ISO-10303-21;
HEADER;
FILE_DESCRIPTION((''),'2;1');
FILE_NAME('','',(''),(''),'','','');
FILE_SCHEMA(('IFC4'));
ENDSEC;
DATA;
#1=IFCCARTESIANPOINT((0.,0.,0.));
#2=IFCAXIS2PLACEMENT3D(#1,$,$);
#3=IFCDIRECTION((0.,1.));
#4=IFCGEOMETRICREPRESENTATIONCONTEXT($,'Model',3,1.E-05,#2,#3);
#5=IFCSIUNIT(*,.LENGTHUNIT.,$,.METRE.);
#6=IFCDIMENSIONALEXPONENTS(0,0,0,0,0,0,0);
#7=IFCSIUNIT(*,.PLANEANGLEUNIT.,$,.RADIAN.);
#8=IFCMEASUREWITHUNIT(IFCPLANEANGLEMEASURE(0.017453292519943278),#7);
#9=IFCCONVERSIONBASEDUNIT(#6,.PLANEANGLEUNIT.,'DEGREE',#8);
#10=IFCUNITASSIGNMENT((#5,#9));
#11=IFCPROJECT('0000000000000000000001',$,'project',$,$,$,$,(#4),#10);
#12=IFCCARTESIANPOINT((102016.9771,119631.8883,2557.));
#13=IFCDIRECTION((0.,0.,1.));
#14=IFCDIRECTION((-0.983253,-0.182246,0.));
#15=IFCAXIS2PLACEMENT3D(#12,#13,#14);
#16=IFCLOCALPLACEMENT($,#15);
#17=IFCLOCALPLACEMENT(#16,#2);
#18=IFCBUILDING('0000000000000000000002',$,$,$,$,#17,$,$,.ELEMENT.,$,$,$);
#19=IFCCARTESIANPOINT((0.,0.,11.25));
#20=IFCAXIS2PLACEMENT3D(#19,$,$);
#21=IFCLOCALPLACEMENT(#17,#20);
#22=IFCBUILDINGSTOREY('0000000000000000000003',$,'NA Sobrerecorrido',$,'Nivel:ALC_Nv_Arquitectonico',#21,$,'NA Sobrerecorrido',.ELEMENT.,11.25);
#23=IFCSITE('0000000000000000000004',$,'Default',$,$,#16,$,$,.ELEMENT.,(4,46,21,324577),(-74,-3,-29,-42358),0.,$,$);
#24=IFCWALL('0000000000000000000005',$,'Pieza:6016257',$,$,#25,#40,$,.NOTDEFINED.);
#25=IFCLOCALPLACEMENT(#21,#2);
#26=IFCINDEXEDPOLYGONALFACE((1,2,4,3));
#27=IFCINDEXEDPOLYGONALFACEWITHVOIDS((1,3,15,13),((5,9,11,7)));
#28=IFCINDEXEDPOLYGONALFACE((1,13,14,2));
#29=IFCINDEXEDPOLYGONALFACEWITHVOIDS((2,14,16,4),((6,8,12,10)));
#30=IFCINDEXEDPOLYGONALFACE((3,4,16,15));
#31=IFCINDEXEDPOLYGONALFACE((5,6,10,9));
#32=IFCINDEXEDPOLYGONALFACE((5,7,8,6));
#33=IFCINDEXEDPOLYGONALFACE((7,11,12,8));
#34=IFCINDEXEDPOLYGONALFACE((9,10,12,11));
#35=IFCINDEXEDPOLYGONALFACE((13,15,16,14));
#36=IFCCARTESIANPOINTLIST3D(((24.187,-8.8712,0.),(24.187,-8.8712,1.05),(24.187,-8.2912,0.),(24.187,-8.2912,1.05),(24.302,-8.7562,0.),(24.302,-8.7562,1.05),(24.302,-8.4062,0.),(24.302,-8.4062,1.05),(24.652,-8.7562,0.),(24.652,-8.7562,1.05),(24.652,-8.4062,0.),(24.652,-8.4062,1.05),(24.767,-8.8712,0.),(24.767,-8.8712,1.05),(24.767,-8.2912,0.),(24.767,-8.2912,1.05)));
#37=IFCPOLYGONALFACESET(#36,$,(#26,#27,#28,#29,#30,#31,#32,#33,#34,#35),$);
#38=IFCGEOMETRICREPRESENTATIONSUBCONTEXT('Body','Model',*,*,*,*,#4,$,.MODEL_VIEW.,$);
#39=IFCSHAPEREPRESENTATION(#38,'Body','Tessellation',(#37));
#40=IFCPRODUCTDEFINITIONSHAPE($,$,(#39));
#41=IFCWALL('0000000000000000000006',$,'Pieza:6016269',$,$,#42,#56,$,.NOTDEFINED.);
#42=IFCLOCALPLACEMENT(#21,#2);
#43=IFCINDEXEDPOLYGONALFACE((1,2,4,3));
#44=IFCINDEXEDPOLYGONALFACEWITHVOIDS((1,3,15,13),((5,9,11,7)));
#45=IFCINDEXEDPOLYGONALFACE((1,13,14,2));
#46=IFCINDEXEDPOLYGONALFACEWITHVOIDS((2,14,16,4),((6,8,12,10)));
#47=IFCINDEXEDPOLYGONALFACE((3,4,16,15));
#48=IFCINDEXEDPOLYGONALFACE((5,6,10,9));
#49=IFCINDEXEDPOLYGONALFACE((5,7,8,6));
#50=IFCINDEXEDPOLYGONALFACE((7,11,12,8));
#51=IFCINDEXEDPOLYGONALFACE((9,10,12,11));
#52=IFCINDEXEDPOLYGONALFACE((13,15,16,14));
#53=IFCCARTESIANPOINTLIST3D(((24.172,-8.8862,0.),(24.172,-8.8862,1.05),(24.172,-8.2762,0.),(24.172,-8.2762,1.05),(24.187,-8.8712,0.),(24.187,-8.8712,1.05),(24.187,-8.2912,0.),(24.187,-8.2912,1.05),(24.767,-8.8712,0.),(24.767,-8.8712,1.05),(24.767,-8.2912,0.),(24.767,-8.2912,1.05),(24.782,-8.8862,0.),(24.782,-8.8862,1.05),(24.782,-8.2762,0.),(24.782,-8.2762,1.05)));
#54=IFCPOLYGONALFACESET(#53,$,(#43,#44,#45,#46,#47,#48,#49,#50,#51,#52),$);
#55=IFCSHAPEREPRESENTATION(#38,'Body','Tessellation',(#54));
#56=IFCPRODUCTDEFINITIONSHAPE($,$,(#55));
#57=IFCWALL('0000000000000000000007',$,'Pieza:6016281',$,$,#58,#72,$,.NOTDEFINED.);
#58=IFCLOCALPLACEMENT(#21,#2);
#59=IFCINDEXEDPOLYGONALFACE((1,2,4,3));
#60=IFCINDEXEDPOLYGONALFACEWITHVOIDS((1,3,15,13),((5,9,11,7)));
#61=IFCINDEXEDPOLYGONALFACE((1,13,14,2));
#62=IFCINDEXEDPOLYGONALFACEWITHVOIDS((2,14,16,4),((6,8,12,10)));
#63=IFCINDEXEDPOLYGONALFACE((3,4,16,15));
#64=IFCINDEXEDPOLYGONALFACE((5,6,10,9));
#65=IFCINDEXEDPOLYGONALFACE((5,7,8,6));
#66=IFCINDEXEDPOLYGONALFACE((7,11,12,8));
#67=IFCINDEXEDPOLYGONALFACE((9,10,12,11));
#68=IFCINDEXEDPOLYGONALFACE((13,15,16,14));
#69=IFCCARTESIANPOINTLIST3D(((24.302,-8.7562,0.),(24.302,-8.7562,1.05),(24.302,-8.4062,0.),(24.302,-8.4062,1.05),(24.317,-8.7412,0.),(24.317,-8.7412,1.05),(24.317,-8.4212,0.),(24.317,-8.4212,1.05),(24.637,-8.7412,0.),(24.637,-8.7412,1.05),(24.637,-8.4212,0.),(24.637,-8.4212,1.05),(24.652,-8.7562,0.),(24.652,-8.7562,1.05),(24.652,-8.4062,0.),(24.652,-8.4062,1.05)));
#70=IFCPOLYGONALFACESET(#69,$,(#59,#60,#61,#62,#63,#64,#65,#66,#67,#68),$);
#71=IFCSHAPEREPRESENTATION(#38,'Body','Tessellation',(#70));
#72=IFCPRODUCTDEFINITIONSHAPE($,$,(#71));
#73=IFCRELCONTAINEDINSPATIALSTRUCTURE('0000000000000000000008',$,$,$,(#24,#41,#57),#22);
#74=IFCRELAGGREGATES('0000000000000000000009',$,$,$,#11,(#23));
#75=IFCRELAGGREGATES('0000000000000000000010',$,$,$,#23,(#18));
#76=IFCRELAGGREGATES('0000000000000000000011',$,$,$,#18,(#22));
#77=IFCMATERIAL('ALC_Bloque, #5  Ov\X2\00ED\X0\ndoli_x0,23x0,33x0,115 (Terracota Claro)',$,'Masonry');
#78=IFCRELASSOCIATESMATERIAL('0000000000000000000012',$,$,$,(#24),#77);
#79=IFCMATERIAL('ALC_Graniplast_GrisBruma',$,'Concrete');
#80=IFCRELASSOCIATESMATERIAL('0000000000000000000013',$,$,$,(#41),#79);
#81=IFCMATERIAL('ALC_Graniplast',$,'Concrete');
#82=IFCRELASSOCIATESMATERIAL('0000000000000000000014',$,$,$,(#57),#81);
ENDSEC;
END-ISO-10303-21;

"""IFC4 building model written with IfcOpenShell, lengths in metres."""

from ifc_helpers import new_model, entity, si_unit, converted_unit, direction, frame, origin, place, context, subcontext, project, spatial, polyline, outline, extrude, material, element, save


model = new_model("IFC4")

# Units and contexts
model_context = context("Model", 3, precision=1e-05, world=origin(), true_north=direction((0.0, 1.0)))
body_context = subcontext(model_context, "Body", "Model", "MODEL_VIEW")
ifc_project = project(units=[si_unit("LENGTHUNIT", "METRE"), converted_unit("PLANEANGLEUNIT", "DEGREE", entity("IfcPlaneAngleMeasure", 0.017453292519943278), si_unit("PLANEANGLEUNIT", "RADIAN"), dimensions=[0, 0, 0, 0, 0, 0, 0])], contexts=[model_context])

# Site, building, storey
site_placement = place(None, frame((102016.9771, 119631.8883, 2557.0), z_axis=(0.0, 0.0, 1.0), x_axis=(-0.983253, -0.182246, 0.0)))
site = spatial("IfcSite", under=ifc_project, at=site_placement, Name="Default", CompositionType="ELEMENT", RefLatitude=(4, 46, 21, 324577), RefLongitude=(-74, -3, -29, -42358), RefElevation=0.0)
building_placement = place(site_placement, origin())
building = spatial("IfcBuilding", under=site, at=building_placement, CompositionType="ELEMENT")
storey_placement = place(building_placement, frame((0.0, 0.0, 11.25)))
storey = spatial("IfcBuildingStorey", under=building, at=storey_placement, Name="NA Sobrerecorrido", ObjectType="Nivel:ALC_Nv_Arquitectonico", LongName="NA Sobrerecorrido", CompositionType="ELEMENT", Elevation=11.25)

# Walls
ifc_material_1 = material(Name="ALC_Bloque, #5  Ovíndoli_x0,23x0,33x0,115 (Terracota Claro)", Category="Masonry")
wall_1_placement = place(storey_placement, frame((0.0, 0.0, -1.65)))
element("IfcWall", 1, at=wall_1_placement, inside=storey, material=ifc_material_1, Name="Pieza:6016257", PredefinedType="NOTDEFINED", context=body_context, shape_type="SweptSolid", body=[
    extrude(outline(polyline([(-0.29, -0.29), (0.29, -0.29), (0.29, 0.29), (-0.29, 0.29), (-0.29, -0.29)]), holes=[polyline([(-0.175, 0.175), (0.175, 0.175), (0.175, -0.175), (-0.175, -0.175), (-0.175, 0.175)])]), frame((24.477, -8.5812, 1.65), z_axis=(0.0, 0.0, 1.0), x_axis=(0.0, 1.0, 0.0)), (0.0, 0.0, 1.0), 1.05),
])
ifc_material_2 = material(Name="ALC_Graniplast_GrisBruma", Category="Concrete")
wall_2_placement = place(storey_placement, frame((0.0, 0.0, -1.65)))
element("IfcWall", 2, at=wall_2_placement, inside=storey, material=ifc_material_2, Name="Pieza:6016269", PredefinedType="NOTDEFINED", context=body_context, shape_type="SweptSolid", body=[
    extrude(outline(polyline([(-0.305, -0.305), (0.305, -0.305), (0.305, 0.305), (-0.305, 0.305), (-0.305, -0.305)]), holes=[polyline([(0.29, 0.29), (0.29, -0.29), (-0.29, -0.29), (-0.29, 0.29), (0.29, 0.29)])]), frame((24.477, -8.5812, 1.65), z_axis=(0.0, 0.0, 1.0), x_axis=(-1.0, 0.0, 0.0)), (0.0, 0.0, 1.0), 1.05),
])
ifc_material_3 = material(Name="ALC_Graniplast", Category="Concrete")
wall_3_placement = place(storey_placement, frame((0.0, 0.0, -1.65)))
element("IfcWall", 3, at=wall_3_placement, inside=storey, material=ifc_material_3, Name="Pieza:6016281", PredefinedType="NOTDEFINED", context=body_context, shape_type="SweptSolid", body=[
    extrude(outline(polyline([(-0.175, -0.175), (0.175, -0.175), (0.175, 0.175), (-0.175, 0.175), (-0.175, -0.175)]), holes=[polyline([(-0.16, 0.16), (0.16, 0.16), (0.16, -0.16), (-0.16, -0.16), (-0.16, 0.16)])]), frame((24.477, -8.5812, 1.65), z_axis=(0.0, 0.0, 1.0), x_axis=(0.0, 1.0, 0.0)), (0.0, 0.0, 1.0), 1.05),
])

save(model, "model.ifc")
